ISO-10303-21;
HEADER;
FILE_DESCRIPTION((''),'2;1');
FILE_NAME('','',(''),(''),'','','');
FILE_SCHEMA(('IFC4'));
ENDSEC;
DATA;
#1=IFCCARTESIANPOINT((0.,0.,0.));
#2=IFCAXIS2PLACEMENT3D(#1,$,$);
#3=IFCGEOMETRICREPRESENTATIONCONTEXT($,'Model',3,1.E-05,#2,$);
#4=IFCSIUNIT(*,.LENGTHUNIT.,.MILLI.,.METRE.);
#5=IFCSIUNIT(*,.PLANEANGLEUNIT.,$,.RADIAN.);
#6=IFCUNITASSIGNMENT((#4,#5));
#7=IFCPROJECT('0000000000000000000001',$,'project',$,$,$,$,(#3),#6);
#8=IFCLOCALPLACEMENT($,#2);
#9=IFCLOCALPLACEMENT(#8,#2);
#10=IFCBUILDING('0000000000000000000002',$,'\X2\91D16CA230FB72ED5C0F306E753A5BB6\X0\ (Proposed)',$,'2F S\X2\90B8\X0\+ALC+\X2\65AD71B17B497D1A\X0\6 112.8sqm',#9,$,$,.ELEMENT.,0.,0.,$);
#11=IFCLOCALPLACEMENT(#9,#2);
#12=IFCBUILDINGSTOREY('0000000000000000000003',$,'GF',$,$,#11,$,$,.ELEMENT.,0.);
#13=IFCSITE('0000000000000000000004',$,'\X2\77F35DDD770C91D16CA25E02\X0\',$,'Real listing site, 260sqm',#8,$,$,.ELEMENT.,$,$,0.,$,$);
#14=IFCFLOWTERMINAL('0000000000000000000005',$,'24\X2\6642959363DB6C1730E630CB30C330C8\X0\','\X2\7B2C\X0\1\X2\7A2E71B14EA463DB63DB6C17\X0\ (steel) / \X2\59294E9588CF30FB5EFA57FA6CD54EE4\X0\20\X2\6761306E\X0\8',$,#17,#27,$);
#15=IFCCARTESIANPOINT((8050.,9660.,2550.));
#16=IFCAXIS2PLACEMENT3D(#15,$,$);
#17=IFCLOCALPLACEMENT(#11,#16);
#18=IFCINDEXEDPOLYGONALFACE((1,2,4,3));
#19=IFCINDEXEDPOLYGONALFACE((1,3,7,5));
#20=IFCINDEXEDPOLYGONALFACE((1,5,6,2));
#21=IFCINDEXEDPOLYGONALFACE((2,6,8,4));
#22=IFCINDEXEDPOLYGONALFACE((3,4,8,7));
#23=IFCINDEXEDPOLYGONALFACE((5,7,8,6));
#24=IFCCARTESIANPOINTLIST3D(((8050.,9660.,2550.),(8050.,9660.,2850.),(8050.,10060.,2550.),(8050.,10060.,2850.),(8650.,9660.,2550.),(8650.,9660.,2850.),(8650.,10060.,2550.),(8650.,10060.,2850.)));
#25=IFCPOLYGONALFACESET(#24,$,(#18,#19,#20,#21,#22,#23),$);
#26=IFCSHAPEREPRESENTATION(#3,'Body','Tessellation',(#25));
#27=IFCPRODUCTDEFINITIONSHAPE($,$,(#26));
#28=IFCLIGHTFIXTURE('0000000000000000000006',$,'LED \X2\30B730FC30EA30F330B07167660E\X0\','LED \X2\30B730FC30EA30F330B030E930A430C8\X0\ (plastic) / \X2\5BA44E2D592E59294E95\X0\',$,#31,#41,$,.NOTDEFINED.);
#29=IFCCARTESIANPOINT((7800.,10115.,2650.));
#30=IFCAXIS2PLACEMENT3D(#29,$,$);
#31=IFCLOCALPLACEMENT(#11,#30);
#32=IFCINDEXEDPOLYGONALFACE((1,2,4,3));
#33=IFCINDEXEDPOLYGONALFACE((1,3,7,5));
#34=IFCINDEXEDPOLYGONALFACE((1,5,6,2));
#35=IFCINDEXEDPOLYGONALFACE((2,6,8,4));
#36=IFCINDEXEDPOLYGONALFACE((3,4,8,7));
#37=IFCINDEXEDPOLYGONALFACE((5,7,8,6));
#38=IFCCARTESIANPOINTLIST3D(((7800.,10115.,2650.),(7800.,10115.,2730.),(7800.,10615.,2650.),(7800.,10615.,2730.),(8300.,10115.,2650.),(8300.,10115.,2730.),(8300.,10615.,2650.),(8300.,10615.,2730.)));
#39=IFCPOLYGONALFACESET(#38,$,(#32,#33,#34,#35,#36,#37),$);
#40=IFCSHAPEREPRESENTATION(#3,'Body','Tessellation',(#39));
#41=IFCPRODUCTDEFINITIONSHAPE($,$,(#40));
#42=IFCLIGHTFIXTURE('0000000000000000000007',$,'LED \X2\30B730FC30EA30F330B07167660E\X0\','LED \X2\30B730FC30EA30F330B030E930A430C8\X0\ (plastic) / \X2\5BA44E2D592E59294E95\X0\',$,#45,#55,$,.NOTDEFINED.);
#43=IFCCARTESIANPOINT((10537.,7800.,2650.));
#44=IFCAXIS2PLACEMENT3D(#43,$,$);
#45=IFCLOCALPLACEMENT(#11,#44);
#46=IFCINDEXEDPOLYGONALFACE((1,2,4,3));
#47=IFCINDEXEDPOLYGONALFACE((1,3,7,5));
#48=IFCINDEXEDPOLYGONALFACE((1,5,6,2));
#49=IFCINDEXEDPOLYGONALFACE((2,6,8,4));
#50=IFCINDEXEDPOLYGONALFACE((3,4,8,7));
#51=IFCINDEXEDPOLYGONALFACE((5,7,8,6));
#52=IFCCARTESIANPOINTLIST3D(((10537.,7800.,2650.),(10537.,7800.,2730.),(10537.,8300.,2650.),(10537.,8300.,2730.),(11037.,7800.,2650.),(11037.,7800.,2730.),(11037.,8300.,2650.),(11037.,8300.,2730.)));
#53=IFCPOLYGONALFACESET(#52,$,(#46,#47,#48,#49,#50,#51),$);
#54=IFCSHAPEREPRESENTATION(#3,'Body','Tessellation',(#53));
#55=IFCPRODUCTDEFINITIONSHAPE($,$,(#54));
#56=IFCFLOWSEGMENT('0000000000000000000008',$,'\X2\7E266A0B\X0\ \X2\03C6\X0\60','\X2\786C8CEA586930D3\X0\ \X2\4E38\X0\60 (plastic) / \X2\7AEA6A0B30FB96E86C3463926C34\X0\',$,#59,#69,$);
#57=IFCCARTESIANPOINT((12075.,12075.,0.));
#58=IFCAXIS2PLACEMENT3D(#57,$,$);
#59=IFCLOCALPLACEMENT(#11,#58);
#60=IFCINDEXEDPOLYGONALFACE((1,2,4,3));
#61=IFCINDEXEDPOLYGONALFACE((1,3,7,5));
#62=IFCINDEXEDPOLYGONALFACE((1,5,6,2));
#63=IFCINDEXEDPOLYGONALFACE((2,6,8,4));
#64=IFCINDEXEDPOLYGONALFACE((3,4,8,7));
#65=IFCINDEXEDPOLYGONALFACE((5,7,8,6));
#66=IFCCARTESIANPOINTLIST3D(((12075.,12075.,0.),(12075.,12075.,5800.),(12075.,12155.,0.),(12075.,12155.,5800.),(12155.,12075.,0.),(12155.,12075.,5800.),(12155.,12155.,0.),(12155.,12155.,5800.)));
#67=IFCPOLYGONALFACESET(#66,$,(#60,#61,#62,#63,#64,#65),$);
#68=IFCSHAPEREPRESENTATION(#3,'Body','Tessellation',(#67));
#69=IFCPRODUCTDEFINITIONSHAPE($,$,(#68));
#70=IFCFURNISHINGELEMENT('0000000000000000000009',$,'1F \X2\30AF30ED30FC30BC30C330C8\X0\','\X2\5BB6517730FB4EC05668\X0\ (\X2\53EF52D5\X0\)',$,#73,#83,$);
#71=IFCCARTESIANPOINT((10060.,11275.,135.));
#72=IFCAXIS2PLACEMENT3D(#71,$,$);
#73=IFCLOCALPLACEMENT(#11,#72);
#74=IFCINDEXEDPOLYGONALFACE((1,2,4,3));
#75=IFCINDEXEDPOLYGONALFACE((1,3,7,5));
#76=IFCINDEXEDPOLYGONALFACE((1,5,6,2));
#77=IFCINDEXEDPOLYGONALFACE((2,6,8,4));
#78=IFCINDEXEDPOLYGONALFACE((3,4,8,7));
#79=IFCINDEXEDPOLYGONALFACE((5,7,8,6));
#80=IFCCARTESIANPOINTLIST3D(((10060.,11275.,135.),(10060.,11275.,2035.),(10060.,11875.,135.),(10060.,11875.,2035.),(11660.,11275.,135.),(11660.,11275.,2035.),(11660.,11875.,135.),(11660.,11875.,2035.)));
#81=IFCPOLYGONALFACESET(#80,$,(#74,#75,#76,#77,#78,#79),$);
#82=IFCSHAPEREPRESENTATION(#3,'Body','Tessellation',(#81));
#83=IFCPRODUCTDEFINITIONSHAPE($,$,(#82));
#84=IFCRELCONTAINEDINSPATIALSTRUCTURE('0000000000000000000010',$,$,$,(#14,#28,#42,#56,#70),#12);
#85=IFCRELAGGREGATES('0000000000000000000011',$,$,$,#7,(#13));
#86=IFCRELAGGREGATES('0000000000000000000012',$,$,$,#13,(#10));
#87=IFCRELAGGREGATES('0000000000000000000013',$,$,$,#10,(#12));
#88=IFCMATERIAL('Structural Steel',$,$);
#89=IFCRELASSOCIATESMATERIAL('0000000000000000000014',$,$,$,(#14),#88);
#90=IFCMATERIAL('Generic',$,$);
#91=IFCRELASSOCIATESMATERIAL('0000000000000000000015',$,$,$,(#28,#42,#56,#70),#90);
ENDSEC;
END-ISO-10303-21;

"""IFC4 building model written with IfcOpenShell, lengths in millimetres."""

from ifc_helpers import new_model, si_unit, frame, frame_2d, origin, place, context, project, spatial, rectangle, extrude, material, element, save


model = new_model("IFC4")

# Units and contexts
model_context = context("Model", 3, precision=1e-05, world=origin())
ifc_project = project(units=[si_unit("LENGTHUNIT", "METRE", prefix="MILLI"), si_unit("PLANEANGLEUNIT", "RADIAN")], contexts=[model_context])

# Site, building, storey
site_placement = place(None, origin())
site = spatial("IfcSite", under=ifc_project, at=site_placement, Name="石川県金沢市", ObjectType="Real listing site, 260sqm", CompositionType="ELEMENT", RefElevation=0.0)
building_placement = place(site_placement, origin())
building = spatial("IfcBuilding", under=site, at=building_placement, Name="金沢・狭小の町家 (Proposed)", ObjectType="2F S邸+ALC+断熱等級6 112.8sqm", CompositionType="ELEMENT", ElevationOfRefHeight=0.0, ElevationOfTerrain=0.0)
storey_placement = place(building_placement, origin())
storey = spatial("IfcBuildingStorey", under=building, at=storey_placement, Name="GF", CompositionType="ELEMENT", Elevation=0.0)

# Shared definitions
ifc_material_1 = material(Name="Generic")

# Flow terminal
ifc_material_2 = material(Name="Structural Steel")
flow_terminal_placement = place(storey_placement, frame((8050.0, 9660.0, 2550.0)))
element("IfcFlowTerminal", 1, at=flow_terminal_placement, inside=storey, material=ifc_material_2, Name="24時間換気ユニット", Description="第1種熱交換換気 (steel) / 天井裏・建基法令20条の8", context=model_context, shape_type="SweptSolid", body=[
    extrude(rectangle(XDim=600.0, YDim=400.0, at=frame_2d((300.0, 200.0))), frame((8050.0, 9660.0, 2550.0)), (0.0, 0.0, 1.0), 300.0),
])

# Light fixtures
light_fixture_1_placement = place(storey_placement, frame((7800.0, 10115.0, 2650.0)))
element("IfcLightFixture", 2, at=light_fixture_1_placement, inside=storey, material=ifc_material_1, Name="LED シーリング照明", Description="LED シーリングライト (plastic) / 室中央天井", PredefinedType="NOTDEFINED", context=model_context, shape_type="SweptSolid", body=[
    extrude(rectangle(XDim=500.0, YDim=500.0, at=frame_2d((250.0, 250.0))), frame((7800.0, 10115.0, 2650.0)), (0.0, 0.0, 1.0), 80.0),
])
light_fixture_2_placement = place(storey_placement, frame((10537.0, 7800.0, 2650.0)))
element("IfcLightFixture", 3, at=light_fixture_2_placement, inside=storey, material=ifc_material_1, Name="LED シーリング照明", Description="LED シーリングライト (plastic) / 室中央天井", PredefinedType="NOTDEFINED", context=model_context, shape_type="SweptSolid", body=[
    extrude(rectangle(XDim=500.0, YDim=500.0, at=frame_2d((250.0, 250.0))), frame((10537.0, 7800.0, 2650.0)), (0.0, 0.0, 1.0), 80.0),
])

# Flow segment
flow_segment_placement = place(storey_placement, frame((12075.0, 12075.0, 0.0)))
element("IfcFlowSegment", 4, at=flow_segment_placement, inside=storey, material=ifc_material_1, Name="縦樋 φ60", Description="硬質塩ビ 丸60 (plastic) / 竪樋・雨水排水", context=model_context, shape_type="SweptSolid", body=[
    extrude(rectangle(XDim=80.0, YDim=80.0, at=frame_2d((40.0, 40.0))), frame((12075.0, 12075.0, 0.0)), (0.0, 0.0, 1.0), 5800.0),
])

# Furnishing element
furnishing_placement = place(storey_placement, frame((10060.0, 11275.0, 135.0)))
element("IfcFurnishingElement", 5, at=furnishing_placement, inside=storey, material=ifc_material_1, Name="1F クローゼット", Description="家具・什器 (可動)", context=model_context, shape_type="SweptSolid", body=[
    extrude(rectangle(XDim=1600.0, YDim=600.0, at=frame_2d((800.0, 300.0))), frame((10060.0, 11275.0, 135.0)), (0.0, 0.0, 1.0), 1900.0),
])

save(model, "model.ifc")
